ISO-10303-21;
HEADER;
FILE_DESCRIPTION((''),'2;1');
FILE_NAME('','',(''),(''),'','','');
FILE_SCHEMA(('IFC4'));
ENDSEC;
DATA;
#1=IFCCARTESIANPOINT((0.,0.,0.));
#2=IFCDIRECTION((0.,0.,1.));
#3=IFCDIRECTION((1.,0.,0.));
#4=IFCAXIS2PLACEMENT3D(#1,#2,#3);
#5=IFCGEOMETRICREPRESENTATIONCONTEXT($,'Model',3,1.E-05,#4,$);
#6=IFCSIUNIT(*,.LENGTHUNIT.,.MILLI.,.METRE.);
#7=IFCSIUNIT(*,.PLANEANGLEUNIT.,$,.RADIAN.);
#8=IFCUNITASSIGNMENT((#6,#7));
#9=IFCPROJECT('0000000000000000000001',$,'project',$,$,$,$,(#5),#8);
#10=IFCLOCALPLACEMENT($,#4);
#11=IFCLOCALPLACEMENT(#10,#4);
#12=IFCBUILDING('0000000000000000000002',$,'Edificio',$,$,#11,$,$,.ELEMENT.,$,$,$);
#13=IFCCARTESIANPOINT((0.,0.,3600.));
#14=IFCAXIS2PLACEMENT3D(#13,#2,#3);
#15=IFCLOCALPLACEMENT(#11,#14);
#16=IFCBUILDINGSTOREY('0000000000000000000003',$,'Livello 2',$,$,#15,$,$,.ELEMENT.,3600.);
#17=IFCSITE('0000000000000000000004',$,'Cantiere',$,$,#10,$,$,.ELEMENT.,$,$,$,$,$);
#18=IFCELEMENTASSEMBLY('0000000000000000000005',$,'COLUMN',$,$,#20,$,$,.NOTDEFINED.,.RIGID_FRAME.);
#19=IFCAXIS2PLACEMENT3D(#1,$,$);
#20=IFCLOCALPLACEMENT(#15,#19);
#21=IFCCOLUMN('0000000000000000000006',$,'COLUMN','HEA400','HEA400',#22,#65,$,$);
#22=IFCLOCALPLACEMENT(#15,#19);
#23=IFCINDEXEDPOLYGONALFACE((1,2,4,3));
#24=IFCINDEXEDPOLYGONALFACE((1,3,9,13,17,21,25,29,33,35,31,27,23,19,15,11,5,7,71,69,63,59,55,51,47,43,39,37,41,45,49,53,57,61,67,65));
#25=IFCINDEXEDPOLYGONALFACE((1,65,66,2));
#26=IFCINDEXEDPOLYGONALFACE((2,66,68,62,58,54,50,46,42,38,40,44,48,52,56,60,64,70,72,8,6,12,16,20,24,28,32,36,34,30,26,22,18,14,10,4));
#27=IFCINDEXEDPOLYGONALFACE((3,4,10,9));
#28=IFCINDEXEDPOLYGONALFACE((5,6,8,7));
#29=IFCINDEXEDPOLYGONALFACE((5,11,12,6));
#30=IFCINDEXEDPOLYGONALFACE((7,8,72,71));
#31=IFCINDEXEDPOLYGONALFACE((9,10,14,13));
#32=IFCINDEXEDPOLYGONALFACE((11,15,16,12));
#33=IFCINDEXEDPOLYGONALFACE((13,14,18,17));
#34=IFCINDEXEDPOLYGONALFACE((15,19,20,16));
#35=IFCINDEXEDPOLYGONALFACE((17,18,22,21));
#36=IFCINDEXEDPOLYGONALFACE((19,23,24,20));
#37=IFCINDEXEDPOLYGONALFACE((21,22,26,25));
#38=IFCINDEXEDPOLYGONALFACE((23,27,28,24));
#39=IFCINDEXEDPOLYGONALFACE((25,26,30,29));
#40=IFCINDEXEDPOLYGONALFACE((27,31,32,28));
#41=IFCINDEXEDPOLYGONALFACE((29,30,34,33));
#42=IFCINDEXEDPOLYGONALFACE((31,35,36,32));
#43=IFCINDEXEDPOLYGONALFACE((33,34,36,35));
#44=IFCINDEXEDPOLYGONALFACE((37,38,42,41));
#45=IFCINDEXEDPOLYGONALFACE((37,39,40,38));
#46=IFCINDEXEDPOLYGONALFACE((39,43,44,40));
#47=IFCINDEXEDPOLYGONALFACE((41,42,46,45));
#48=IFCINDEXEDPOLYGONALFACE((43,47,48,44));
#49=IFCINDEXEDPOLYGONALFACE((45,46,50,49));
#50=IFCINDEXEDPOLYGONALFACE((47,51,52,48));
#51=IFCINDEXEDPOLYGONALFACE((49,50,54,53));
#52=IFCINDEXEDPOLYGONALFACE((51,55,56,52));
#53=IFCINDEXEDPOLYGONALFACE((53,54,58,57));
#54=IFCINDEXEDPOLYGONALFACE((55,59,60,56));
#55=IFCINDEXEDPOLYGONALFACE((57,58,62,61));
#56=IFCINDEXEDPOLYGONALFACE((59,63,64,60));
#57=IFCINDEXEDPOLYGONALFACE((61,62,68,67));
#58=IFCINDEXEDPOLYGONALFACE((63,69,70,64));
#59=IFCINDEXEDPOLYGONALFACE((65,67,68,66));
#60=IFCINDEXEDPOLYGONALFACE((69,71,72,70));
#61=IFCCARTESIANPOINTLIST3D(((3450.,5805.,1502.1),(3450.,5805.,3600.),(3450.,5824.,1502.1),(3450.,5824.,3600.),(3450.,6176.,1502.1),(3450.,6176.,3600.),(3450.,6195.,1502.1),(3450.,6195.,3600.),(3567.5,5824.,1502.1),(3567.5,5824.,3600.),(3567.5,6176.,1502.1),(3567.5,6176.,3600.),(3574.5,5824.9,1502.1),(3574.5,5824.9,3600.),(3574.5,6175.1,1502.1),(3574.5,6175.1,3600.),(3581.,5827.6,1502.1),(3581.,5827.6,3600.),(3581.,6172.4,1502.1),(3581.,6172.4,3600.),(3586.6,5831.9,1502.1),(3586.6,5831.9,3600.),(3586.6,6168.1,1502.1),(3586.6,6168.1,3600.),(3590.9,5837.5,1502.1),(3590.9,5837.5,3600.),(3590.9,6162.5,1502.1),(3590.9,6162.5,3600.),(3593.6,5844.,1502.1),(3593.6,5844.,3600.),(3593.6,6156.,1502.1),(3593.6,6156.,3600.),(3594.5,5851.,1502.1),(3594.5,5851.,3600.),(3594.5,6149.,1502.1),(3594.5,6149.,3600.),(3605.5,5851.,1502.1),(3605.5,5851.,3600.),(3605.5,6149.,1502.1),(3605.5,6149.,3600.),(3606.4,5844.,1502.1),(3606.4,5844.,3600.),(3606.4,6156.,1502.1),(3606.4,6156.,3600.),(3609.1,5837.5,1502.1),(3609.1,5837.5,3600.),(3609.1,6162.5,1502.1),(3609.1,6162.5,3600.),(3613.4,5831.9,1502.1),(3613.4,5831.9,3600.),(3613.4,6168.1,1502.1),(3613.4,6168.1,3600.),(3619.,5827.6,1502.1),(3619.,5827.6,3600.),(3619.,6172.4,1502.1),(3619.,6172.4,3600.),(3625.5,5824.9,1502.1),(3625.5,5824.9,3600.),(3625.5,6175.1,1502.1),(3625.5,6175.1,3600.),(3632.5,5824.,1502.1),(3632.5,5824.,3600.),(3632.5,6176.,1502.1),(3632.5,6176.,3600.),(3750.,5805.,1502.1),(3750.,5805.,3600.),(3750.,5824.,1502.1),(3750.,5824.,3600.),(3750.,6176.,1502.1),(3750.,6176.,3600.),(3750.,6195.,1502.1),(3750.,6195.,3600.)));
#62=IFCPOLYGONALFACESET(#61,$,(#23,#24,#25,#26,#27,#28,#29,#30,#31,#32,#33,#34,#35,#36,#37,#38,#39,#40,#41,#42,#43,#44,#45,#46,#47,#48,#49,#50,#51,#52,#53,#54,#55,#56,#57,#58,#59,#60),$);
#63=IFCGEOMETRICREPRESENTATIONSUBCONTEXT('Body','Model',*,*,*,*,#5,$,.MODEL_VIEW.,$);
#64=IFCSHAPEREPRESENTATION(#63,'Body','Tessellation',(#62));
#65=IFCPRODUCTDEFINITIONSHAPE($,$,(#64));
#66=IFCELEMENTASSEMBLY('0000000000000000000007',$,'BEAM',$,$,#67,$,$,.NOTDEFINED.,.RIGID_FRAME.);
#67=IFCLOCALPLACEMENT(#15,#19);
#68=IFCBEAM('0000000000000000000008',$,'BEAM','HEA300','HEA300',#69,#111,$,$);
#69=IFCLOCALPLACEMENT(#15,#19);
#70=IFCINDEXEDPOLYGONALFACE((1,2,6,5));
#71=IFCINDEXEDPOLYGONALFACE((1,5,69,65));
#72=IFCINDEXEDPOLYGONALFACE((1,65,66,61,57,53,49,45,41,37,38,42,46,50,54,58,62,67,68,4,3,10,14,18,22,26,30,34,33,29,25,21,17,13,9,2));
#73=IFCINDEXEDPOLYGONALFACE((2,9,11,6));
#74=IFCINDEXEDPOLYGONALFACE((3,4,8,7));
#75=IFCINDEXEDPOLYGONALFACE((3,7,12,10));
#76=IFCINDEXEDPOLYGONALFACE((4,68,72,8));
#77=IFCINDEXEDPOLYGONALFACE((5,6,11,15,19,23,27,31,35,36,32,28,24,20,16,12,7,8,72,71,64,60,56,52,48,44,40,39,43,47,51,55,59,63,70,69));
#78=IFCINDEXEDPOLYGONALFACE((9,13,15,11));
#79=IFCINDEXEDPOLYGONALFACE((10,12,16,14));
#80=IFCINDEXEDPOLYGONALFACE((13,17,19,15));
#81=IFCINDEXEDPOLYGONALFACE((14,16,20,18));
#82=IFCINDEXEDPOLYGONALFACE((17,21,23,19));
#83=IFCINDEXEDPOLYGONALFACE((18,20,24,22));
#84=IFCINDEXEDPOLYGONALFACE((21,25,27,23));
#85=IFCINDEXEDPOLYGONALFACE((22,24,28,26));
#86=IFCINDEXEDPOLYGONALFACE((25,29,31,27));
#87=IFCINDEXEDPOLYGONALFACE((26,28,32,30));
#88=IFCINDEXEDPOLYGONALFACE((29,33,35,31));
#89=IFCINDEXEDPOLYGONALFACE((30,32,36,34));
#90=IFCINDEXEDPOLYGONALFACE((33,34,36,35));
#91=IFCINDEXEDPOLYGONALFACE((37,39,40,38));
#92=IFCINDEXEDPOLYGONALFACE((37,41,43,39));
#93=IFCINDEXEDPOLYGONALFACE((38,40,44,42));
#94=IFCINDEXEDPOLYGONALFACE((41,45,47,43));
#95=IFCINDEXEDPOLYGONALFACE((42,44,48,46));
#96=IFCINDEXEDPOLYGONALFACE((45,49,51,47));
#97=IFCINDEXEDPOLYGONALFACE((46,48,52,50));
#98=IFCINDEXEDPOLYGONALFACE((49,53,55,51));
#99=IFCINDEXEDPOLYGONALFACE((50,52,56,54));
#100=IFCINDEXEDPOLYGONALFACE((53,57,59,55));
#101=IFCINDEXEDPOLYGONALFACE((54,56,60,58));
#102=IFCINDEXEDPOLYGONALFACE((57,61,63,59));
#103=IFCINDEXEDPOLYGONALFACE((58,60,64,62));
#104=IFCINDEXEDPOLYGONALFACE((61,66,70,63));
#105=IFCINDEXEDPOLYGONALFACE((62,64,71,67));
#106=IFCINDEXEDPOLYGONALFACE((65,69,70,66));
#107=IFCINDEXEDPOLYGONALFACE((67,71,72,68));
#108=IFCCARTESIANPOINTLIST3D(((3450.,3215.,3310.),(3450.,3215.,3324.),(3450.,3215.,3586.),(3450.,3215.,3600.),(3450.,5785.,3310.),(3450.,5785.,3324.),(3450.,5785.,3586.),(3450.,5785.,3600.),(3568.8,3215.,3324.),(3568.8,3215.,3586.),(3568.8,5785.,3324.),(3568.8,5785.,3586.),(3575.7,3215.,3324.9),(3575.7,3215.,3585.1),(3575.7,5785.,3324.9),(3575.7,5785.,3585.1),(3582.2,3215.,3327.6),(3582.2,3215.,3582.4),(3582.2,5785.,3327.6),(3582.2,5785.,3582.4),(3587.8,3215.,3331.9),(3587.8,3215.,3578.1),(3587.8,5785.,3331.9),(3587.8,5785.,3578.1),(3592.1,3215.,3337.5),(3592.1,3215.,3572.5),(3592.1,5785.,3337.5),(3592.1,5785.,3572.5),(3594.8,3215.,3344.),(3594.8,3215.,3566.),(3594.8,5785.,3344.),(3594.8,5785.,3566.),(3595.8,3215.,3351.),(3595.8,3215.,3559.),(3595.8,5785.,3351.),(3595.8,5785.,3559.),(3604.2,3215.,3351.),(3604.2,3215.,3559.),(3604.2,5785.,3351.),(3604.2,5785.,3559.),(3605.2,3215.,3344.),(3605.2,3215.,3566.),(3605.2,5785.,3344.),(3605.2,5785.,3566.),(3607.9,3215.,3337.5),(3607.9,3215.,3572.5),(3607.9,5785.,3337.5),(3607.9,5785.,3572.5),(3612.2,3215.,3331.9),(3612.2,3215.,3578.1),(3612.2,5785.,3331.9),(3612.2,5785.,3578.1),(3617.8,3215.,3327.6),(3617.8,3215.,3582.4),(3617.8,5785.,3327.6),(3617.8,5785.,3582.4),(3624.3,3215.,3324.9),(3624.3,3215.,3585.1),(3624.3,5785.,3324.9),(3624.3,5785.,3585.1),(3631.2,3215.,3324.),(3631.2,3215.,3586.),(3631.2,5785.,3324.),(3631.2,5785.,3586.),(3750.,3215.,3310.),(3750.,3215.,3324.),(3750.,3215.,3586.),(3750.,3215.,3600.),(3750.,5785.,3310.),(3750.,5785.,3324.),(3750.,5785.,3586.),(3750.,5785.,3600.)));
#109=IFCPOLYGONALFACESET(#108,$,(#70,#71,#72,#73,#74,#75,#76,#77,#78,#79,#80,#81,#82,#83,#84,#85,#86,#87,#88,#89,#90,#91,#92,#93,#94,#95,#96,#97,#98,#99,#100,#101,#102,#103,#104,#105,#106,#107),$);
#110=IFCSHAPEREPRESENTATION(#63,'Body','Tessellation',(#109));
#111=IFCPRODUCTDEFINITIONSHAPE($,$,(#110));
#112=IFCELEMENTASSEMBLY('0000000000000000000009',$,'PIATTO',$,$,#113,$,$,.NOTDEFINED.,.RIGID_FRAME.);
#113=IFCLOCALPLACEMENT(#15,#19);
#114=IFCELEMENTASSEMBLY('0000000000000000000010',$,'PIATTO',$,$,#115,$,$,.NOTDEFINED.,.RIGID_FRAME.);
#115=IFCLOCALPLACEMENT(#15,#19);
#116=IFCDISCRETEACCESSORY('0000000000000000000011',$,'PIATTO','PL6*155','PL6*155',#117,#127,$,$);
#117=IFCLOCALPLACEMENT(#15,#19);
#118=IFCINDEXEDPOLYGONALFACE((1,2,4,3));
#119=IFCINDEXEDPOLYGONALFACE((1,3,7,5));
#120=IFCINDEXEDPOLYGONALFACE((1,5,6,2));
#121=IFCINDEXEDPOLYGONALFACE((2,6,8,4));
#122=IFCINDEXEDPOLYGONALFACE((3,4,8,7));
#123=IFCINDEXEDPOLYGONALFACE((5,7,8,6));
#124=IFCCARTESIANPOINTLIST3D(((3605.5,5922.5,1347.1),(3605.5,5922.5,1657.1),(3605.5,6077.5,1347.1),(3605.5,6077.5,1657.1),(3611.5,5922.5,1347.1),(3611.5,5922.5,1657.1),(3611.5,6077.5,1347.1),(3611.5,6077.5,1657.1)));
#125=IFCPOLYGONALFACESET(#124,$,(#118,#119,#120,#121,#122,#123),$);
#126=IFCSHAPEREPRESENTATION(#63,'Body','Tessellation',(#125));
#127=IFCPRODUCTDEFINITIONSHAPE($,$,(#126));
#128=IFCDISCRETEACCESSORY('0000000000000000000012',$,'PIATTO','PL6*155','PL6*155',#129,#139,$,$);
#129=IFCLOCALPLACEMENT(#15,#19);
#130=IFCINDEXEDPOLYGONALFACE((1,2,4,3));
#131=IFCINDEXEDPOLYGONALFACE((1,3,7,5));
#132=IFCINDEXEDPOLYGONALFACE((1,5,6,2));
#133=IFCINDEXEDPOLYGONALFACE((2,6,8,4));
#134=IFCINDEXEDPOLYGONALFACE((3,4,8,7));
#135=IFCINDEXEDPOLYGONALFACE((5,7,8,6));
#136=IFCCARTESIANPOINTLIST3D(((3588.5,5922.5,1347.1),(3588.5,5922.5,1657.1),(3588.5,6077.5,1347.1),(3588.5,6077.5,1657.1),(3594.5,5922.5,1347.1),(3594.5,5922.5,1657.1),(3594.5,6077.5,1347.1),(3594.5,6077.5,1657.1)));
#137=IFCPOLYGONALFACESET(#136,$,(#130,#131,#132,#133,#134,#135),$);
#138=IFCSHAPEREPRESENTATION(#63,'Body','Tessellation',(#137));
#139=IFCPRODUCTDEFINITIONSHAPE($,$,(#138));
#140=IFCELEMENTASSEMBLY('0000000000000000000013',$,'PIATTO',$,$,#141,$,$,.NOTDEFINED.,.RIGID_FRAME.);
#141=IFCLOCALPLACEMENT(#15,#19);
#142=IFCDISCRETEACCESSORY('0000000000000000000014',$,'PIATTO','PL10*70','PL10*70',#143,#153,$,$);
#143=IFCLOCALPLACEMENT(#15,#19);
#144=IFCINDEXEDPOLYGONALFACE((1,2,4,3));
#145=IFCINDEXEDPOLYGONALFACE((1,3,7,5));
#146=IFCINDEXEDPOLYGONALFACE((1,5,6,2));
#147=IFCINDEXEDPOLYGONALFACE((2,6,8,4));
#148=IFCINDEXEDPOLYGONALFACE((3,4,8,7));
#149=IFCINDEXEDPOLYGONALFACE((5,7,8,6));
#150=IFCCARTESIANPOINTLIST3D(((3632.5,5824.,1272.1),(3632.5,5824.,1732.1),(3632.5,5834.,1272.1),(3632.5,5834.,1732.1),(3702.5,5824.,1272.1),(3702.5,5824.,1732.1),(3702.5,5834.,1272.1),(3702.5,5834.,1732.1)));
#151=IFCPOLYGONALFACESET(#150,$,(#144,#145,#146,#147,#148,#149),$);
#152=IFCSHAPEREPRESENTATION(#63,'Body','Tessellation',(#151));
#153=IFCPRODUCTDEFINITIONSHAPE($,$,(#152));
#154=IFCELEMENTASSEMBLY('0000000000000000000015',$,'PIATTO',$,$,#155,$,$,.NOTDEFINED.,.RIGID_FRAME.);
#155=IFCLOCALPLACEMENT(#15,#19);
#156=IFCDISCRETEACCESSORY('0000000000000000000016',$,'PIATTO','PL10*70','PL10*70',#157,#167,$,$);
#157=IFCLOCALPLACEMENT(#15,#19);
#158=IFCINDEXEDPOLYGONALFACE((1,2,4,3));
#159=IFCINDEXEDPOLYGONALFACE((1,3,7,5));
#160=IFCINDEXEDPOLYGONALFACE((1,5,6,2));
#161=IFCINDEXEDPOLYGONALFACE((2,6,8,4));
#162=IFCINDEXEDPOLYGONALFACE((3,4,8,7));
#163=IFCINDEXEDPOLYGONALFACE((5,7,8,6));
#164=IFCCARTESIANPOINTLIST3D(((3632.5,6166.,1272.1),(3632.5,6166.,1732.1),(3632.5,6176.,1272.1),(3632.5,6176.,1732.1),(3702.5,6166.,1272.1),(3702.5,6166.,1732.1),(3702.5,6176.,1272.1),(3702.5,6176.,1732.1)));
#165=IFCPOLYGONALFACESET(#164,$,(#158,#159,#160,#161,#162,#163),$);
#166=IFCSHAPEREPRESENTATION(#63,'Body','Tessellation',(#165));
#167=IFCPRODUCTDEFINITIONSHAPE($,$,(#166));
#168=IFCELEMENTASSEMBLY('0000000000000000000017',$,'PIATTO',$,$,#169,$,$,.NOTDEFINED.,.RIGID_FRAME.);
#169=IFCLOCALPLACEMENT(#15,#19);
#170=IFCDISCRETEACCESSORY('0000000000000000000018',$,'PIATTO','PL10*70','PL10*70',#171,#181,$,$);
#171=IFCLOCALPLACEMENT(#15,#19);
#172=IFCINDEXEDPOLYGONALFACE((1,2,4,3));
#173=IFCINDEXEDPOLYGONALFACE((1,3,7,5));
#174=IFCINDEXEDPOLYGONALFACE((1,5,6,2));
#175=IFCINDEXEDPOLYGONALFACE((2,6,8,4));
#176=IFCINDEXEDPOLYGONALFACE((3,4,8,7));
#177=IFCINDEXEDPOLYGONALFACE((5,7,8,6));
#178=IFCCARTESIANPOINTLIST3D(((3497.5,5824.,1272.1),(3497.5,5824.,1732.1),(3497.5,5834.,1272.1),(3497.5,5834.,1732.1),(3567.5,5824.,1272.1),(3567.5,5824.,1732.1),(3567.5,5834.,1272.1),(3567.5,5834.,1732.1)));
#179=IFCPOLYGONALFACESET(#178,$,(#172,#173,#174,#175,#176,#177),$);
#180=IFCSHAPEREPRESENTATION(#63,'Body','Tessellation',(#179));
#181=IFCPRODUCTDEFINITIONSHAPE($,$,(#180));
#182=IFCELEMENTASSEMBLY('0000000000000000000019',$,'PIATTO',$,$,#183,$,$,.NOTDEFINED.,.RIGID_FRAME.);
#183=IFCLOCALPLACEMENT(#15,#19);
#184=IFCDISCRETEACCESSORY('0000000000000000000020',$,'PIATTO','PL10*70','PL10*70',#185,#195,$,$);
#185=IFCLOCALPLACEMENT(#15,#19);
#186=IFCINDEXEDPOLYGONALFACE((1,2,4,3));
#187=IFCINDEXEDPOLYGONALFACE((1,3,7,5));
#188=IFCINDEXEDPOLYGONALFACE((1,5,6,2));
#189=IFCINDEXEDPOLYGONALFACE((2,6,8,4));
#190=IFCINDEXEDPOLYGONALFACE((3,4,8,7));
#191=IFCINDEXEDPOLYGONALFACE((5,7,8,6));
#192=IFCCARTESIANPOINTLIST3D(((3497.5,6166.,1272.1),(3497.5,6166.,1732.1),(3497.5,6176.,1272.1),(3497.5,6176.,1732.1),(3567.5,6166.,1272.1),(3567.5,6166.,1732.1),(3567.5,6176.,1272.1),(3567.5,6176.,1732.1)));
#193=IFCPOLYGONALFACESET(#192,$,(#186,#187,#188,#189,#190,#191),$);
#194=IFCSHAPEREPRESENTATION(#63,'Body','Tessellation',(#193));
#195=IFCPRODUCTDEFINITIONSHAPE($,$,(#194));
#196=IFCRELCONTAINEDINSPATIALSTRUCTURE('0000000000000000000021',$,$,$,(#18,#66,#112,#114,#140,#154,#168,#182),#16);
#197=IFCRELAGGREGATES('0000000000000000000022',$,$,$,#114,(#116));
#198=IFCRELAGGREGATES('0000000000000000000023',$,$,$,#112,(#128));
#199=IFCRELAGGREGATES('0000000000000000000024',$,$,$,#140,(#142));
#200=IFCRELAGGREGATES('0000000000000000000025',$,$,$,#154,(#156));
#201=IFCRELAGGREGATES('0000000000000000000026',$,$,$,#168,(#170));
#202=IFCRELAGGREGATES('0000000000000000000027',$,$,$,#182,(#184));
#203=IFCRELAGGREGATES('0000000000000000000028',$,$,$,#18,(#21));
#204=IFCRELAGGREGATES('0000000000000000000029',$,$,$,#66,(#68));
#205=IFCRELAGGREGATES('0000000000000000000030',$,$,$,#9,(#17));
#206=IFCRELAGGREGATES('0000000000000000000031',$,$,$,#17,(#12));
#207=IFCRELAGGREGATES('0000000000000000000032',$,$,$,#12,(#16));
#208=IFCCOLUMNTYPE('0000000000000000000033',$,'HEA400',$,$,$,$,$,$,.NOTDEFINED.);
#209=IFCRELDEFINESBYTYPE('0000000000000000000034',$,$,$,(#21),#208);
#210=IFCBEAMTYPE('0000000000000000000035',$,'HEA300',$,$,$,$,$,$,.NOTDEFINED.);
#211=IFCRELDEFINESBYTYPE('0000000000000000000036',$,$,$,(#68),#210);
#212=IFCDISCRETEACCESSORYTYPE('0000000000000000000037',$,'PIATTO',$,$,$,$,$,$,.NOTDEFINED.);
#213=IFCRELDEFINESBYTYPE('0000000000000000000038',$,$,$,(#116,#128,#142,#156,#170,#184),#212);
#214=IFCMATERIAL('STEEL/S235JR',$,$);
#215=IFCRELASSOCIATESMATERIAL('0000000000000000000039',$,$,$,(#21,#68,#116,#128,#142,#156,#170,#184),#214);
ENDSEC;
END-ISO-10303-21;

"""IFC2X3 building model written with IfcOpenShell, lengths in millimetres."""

from ifc_helpers import new_model, si_unit, frame, origin_with_axes, origin_2d_with_axis, place, context, subcontext, project, spatial, polyline, i_section, outline, extrude, clip, halfspace, material, type_object, element, aggregate, save


model = new_model("IFC2X3")

# Units and contexts
model_context = context("Model", 3, precision=1e-05, world=origin_with_axes())
body_context = subcontext(model_context, "Body", "Model", "MODEL_VIEW")
ifc_project = project(units=[si_unit("LENGTHUNIT", "METRE", prefix="MILLI"), si_unit("PLANEANGLEUNIT", "RADIAN")], contexts=[model_context])

# Site, building, storey
site_placement = place(None, origin_with_axes())
site = spatial("IfcSite", under=ifc_project, at=site_placement, Name="Cantiere", CompositionType="ELEMENT")
building_placement = place(site_placement, origin_with_axes())
building = spatial("IfcBuilding", under=site, at=building_placement, Name="Edificio", CompositionType="ELEMENT")
storey_placement = place(building_placement, frame((0.0, 0.0, 3600.0), z_axis=(0.0, 0.0, 1.0), x_axis=(1.0, 0.0, 0.0)))
storey = spatial("IfcBuildingStorey", under=building, at=storey_placement, Name="Livello 2", CompositionType="ELEMENT", Elevation=3600.0)

# Element assembly, column
assembly_1_placement = place(storey_placement, origin_with_axes())
assembly_1 = element("IfcElementAssembly", 1, at=assembly_1_placement, inside=storey, Name="COLUMN", AssemblyPlace="NOTDEFINED", PredefinedType="RIGID_FRAME")
ifc_material_1 = material(Name="STEEL/S235JR")
column_type = type_object("IfcColumnType", Name="HEA400", PredefinedType="NOTDEFINED")
column_placement = place(assembly_1_placement, frame((3600.0, 6000.0, 1502.1), z_axis=(0.0, 0.0, 1.0), x_axis=(0.0, 1.0, 0.0)))
column = element("IfcColumn", 2, at=column_placement, type_object=column_type, material=ifc_material_1, Name="COLUMN", Description="HEA400", ObjectType="HEA400", context=body_context, shape_type="Clipping", body=[
    clip(extrude(i_section(OverallWidth=300.0, OverallDepth=390.0, WebThickness=11.0, FlangeThickness=19.0, FilletRadius=27.0, at=origin_2d_with_axis()), frame((0.0, 0.0, 2097.9), z_axis=(0.0, 0.0, -1.0), x_axis=(0.0, 1.0, 0.0)), (0.0, 0.0, 1.0), 2097.9), halfspace(frame((1000.0, 0.0, 0.0), z_axis=(0.0, 0.0, -1.0), x_axis=(0.0, 1.0, 0.0)), False)),
])

# Element assembly, beam
assembly_2_placement = place(storey_placement, origin_with_axes())
assembly_2 = element("IfcElementAssembly", 3, at=assembly_2_placement, inside=storey, Name="BEAM", AssemblyPlace="NOTDEFINED", PredefinedType="RIGID_FRAME")
beam_type = type_object("IfcBeamType", Name="HEA300", PredefinedType="NOTDEFINED")
beam_placement = place(assembly_2_placement, frame((3600.0, 6000.0, 3455.0), z_axis=(0.0, 0.0, 1.0), x_axis=(0.0, -1.0, 0.0)))
beam = element("IfcBeam", 4, at=beam_placement, type_object=beam_type, material=ifc_material_1, Name="BEAM", Description="HEA300", ObjectType="HEA300", context=body_context, shape_type="Clipping", body=[
    clip(clip(extrude(i_section(OverallWidth=300.0, OverallDepth=290.0, WebThickness=8.5, FlangeThickness=14.0, FilletRadius=27.0, at=origin_2d_with_axis()), frame((2785.0, 0.0, 0.0), z_axis=(-1.0, 0.0, 0.0), x_axis=(0.0, -1.0, 0.0)), (0.0, 0.0, 1.0), 2570.0), halfspace(frame((2785.0, 0.0, -145.0), z_axis=(-1.0, 0.0, 0.0), x_axis=(0.0, 1.0, 0.0)), True)), halfspace(frame((215.0, 0.0, -145.0), z_axis=(1.0, 0.0, 0.0), x_axis=(0.0, -1.0, 0.0)), True)),
])

# Element assembly
assembly_3_placement = place(storey_placement, origin_with_axes())
assembly_3 = element("IfcElementAssembly", 5, at=assembly_3_placement, inside=storey, Name="PIATTO", AssemblyPlace="NOTDEFINED", PredefinedType="RIGID_FRAME")

# Element assembly, discrete accessory
assembly_4_placement = place(storey_placement, origin_with_axes())
assembly_4 = element("IfcElementAssembly", 6, at=assembly_4_placement, inside=storey, Name="PIATTO", AssemblyPlace="NOTDEFINED", PredefinedType="RIGID_FRAME")
discrete_accessory_type_1 = type_object("IfcDiscreteAccessoryType", Name="PIATTO")
discrete_accessory_1_placement = place(assembly_4_placement, frame((3608.5, 6000.0, 1347.1), z_axis=(-1.0, 0.0, 0.0), x_axis=(0.0, 0.0, 1.0)))
discrete_accessory_1 = element("IfcDiscreteAccessory", 7, at=discrete_accessory_1_placement, type_object=discrete_accessory_type_1, material=ifc_material_1, Name="PIATTO", Description="PL6*155", ObjectType="PL6*155", context=body_context, shape_type="SweptSolid", body=[
    extrude(outline(polyline([(0.0, -77.5), (0.0, 77.5), (310.0, 77.5), (310.0, -77.5), (0.0, -77.5)])), frame((0.0, 0.0, -3.0), z_axis=(0.0, 0.0, 1.0), x_axis=(1.0, 0.0, 0.0)), (0.0, 0.0, 1.0), 6.0),
])
aggregate(assembly_4, [discrete_accessory_1])

# Discrete accessory
discrete_accessory_2_placement = place(assembly_3_placement, frame((3591.5, 6000.0, 1347.1), z_axis=(-1.0, 0.0, 0.0), x_axis=(0.0, 0.0, 1.0)))
discrete_accessory_2 = element("IfcDiscreteAccessory", 8, at=discrete_accessory_2_placement, type_object=discrete_accessory_type_1, material=ifc_material_1, Name="PIATTO", Description="PL6*155", ObjectType="PL6*155", context=body_context, shape_type="SweptSolid", body=[
    extrude(outline(polyline([(0.0, -77.5), (0.0, 77.5), (310.0, 77.5), (310.0, -77.5), (0.0, -77.5)])), frame((0.0, 0.0, -3.0), z_axis=(0.0, 0.0, 1.0), x_axis=(1.0, 0.0, 0.0)), (0.0, 0.0, 1.0), 6.0),
])
aggregate(assembly_3, [discrete_accessory_2])

# Element assemblies, discrete accessories
assembly_5_placement = place(storey_placement, origin_with_axes())
assembly_5 = element("IfcElementAssembly", 9, at=assembly_5_placement, inside=storey, Name="PIATTO", AssemblyPlace="NOTDEFINED", PredefinedType="RIGID_FRAME")
discrete_accessory_3_placement = place(assembly_5_placement, frame((3667.5, 5829.0, 1732.1), z_axis=(0.0, 1.0, 0.0), x_axis=(0.0, 0.0, -1.0)))
discrete_accessory_3 = element("IfcDiscreteAccessory", 10, at=discrete_accessory_3_placement, type_object=discrete_accessory_type_1, material=ifc_material_1, Name="PIATTO", Description="PL10*70", ObjectType="PL10*70", context=body_context, shape_type="SweptSolid", body=[
    extrude(outline(polyline([(460.0, 35.0), (460.0, -35.0), (0.0, -35.0), (0.0, 35.0), (460.0, 35.0)])), frame((0.0, 0.0, -5.0), z_axis=(0.0, 0.0, 1.0), x_axis=(1.0, 0.0, 0.0)), (0.0, 0.0, 1.0), 10.0),
])
aggregate(assembly_5, [discrete_accessory_3])
assembly_6_placement = place(storey_placement, origin_with_axes())
assembly_6 = element("IfcElementAssembly", 11, at=assembly_6_placement, inside=storey, Name="PIATTO", AssemblyPlace="NOTDEFINED", PredefinedType="RIGID_FRAME")
discrete_accessory_4_placement = place(assembly_6_placement, frame((3667.5, 6171.0, 1732.1), z_axis=(0.0, 1.0, 0.0), x_axis=(0.0, 0.0, -1.0)))
discrete_accessory_4 = element("IfcDiscreteAccessory", 12, at=discrete_accessory_4_placement, type_object=discrete_accessory_type_1, material=ifc_material_1, Name="PIATTO", Description="PL10*70", ObjectType="PL10*70", context=body_context, shape_type="SweptSolid", body=[
    extrude(outline(polyline([(460.0, 35.0), (460.0, -35.0), (0.0, -35.0), (0.0, 35.0), (460.0, 35.0)])), frame((0.0, 0.0, -5.0), z_axis=(0.0, 0.0, 1.0), x_axis=(1.0, 0.0, 0.0)), (0.0, 0.0, 1.0), 10.0),
])
assembly_7_placement = place(storey_placement, origin_with_axes())
assembly_7 = element("IfcElementAssembly", 13, at=assembly_7_placement, inside=storey, Name="PIATTO", AssemblyPlace="NOTDEFINED", PredefinedType="RIGID_FRAME")
discrete_accessory_5_placement = place(assembly_7_placement, frame((3532.5, 5829.0, 1732.1), z_axis=(0.0, 1.0, 0.0), x_axis=(0.0, 0.0, -1.0)))
discrete_accessory_5 = element("IfcDiscreteAccessory", 14, at=discrete_accessory_5_placement, type_object=discrete_accessory_type_1, material=ifc_material_1, Name="PIATTO", Description="PL10*70", ObjectType="PL10*70", context=body_context, shape_type="SweptSolid", body=[
    extrude(outline(polyline([(460.0, 35.0), (460.0, -35.0), (0.0, -35.0), (0.0, 35.0), (460.0, 35.0)])), frame((0.0, 0.0, -5.0), z_axis=(0.0, 0.0, 1.0), x_axis=(1.0, 0.0, 0.0)), (0.0, 0.0, 1.0), 10.0),
])
assembly_8_placement = place(storey_placement, origin_with_axes())
assembly_8 = element("IfcElementAssembly", 15, at=assembly_8_placement, inside=storey, Name="PIATTO", AssemblyPlace="NOTDEFINED", PredefinedType="RIGID_FRAME")
discrete_accessory_6_placement = place(assembly_8_placement, frame((3532.5, 6171.0, 1732.1), z_axis=(0.0, 1.0, 0.0), x_axis=(0.0, 0.0, -1.0)))
discrete_accessory_6 = element("IfcDiscreteAccessory", 16, at=discrete_accessory_6_placement, type_object=discrete_accessory_type_1, material=ifc_material_1, Name="PIATTO", Description="PL10*70", ObjectType="PL10*70", context=body_context, shape_type="SweptSolid", body=[
    extrude(outline(polyline([(460.0, 35.0), (460.0, -35.0), (0.0, -35.0), (0.0, 35.0), (460.0, 35.0)])), frame((0.0, 0.0, -5.0), z_axis=(0.0, 0.0, 1.0), x_axis=(1.0, 0.0, 0.0)), (0.0, 0.0, 1.0), 10.0),
])

aggregate(assembly_6, [discrete_accessory_4])
aggregate(assembly_7, [discrete_accessory_5])
aggregate(assembly_8, [discrete_accessory_6])

aggregate(assembly_1, [column])
aggregate(assembly_2, [beam])

save(model, "model.ifc")
